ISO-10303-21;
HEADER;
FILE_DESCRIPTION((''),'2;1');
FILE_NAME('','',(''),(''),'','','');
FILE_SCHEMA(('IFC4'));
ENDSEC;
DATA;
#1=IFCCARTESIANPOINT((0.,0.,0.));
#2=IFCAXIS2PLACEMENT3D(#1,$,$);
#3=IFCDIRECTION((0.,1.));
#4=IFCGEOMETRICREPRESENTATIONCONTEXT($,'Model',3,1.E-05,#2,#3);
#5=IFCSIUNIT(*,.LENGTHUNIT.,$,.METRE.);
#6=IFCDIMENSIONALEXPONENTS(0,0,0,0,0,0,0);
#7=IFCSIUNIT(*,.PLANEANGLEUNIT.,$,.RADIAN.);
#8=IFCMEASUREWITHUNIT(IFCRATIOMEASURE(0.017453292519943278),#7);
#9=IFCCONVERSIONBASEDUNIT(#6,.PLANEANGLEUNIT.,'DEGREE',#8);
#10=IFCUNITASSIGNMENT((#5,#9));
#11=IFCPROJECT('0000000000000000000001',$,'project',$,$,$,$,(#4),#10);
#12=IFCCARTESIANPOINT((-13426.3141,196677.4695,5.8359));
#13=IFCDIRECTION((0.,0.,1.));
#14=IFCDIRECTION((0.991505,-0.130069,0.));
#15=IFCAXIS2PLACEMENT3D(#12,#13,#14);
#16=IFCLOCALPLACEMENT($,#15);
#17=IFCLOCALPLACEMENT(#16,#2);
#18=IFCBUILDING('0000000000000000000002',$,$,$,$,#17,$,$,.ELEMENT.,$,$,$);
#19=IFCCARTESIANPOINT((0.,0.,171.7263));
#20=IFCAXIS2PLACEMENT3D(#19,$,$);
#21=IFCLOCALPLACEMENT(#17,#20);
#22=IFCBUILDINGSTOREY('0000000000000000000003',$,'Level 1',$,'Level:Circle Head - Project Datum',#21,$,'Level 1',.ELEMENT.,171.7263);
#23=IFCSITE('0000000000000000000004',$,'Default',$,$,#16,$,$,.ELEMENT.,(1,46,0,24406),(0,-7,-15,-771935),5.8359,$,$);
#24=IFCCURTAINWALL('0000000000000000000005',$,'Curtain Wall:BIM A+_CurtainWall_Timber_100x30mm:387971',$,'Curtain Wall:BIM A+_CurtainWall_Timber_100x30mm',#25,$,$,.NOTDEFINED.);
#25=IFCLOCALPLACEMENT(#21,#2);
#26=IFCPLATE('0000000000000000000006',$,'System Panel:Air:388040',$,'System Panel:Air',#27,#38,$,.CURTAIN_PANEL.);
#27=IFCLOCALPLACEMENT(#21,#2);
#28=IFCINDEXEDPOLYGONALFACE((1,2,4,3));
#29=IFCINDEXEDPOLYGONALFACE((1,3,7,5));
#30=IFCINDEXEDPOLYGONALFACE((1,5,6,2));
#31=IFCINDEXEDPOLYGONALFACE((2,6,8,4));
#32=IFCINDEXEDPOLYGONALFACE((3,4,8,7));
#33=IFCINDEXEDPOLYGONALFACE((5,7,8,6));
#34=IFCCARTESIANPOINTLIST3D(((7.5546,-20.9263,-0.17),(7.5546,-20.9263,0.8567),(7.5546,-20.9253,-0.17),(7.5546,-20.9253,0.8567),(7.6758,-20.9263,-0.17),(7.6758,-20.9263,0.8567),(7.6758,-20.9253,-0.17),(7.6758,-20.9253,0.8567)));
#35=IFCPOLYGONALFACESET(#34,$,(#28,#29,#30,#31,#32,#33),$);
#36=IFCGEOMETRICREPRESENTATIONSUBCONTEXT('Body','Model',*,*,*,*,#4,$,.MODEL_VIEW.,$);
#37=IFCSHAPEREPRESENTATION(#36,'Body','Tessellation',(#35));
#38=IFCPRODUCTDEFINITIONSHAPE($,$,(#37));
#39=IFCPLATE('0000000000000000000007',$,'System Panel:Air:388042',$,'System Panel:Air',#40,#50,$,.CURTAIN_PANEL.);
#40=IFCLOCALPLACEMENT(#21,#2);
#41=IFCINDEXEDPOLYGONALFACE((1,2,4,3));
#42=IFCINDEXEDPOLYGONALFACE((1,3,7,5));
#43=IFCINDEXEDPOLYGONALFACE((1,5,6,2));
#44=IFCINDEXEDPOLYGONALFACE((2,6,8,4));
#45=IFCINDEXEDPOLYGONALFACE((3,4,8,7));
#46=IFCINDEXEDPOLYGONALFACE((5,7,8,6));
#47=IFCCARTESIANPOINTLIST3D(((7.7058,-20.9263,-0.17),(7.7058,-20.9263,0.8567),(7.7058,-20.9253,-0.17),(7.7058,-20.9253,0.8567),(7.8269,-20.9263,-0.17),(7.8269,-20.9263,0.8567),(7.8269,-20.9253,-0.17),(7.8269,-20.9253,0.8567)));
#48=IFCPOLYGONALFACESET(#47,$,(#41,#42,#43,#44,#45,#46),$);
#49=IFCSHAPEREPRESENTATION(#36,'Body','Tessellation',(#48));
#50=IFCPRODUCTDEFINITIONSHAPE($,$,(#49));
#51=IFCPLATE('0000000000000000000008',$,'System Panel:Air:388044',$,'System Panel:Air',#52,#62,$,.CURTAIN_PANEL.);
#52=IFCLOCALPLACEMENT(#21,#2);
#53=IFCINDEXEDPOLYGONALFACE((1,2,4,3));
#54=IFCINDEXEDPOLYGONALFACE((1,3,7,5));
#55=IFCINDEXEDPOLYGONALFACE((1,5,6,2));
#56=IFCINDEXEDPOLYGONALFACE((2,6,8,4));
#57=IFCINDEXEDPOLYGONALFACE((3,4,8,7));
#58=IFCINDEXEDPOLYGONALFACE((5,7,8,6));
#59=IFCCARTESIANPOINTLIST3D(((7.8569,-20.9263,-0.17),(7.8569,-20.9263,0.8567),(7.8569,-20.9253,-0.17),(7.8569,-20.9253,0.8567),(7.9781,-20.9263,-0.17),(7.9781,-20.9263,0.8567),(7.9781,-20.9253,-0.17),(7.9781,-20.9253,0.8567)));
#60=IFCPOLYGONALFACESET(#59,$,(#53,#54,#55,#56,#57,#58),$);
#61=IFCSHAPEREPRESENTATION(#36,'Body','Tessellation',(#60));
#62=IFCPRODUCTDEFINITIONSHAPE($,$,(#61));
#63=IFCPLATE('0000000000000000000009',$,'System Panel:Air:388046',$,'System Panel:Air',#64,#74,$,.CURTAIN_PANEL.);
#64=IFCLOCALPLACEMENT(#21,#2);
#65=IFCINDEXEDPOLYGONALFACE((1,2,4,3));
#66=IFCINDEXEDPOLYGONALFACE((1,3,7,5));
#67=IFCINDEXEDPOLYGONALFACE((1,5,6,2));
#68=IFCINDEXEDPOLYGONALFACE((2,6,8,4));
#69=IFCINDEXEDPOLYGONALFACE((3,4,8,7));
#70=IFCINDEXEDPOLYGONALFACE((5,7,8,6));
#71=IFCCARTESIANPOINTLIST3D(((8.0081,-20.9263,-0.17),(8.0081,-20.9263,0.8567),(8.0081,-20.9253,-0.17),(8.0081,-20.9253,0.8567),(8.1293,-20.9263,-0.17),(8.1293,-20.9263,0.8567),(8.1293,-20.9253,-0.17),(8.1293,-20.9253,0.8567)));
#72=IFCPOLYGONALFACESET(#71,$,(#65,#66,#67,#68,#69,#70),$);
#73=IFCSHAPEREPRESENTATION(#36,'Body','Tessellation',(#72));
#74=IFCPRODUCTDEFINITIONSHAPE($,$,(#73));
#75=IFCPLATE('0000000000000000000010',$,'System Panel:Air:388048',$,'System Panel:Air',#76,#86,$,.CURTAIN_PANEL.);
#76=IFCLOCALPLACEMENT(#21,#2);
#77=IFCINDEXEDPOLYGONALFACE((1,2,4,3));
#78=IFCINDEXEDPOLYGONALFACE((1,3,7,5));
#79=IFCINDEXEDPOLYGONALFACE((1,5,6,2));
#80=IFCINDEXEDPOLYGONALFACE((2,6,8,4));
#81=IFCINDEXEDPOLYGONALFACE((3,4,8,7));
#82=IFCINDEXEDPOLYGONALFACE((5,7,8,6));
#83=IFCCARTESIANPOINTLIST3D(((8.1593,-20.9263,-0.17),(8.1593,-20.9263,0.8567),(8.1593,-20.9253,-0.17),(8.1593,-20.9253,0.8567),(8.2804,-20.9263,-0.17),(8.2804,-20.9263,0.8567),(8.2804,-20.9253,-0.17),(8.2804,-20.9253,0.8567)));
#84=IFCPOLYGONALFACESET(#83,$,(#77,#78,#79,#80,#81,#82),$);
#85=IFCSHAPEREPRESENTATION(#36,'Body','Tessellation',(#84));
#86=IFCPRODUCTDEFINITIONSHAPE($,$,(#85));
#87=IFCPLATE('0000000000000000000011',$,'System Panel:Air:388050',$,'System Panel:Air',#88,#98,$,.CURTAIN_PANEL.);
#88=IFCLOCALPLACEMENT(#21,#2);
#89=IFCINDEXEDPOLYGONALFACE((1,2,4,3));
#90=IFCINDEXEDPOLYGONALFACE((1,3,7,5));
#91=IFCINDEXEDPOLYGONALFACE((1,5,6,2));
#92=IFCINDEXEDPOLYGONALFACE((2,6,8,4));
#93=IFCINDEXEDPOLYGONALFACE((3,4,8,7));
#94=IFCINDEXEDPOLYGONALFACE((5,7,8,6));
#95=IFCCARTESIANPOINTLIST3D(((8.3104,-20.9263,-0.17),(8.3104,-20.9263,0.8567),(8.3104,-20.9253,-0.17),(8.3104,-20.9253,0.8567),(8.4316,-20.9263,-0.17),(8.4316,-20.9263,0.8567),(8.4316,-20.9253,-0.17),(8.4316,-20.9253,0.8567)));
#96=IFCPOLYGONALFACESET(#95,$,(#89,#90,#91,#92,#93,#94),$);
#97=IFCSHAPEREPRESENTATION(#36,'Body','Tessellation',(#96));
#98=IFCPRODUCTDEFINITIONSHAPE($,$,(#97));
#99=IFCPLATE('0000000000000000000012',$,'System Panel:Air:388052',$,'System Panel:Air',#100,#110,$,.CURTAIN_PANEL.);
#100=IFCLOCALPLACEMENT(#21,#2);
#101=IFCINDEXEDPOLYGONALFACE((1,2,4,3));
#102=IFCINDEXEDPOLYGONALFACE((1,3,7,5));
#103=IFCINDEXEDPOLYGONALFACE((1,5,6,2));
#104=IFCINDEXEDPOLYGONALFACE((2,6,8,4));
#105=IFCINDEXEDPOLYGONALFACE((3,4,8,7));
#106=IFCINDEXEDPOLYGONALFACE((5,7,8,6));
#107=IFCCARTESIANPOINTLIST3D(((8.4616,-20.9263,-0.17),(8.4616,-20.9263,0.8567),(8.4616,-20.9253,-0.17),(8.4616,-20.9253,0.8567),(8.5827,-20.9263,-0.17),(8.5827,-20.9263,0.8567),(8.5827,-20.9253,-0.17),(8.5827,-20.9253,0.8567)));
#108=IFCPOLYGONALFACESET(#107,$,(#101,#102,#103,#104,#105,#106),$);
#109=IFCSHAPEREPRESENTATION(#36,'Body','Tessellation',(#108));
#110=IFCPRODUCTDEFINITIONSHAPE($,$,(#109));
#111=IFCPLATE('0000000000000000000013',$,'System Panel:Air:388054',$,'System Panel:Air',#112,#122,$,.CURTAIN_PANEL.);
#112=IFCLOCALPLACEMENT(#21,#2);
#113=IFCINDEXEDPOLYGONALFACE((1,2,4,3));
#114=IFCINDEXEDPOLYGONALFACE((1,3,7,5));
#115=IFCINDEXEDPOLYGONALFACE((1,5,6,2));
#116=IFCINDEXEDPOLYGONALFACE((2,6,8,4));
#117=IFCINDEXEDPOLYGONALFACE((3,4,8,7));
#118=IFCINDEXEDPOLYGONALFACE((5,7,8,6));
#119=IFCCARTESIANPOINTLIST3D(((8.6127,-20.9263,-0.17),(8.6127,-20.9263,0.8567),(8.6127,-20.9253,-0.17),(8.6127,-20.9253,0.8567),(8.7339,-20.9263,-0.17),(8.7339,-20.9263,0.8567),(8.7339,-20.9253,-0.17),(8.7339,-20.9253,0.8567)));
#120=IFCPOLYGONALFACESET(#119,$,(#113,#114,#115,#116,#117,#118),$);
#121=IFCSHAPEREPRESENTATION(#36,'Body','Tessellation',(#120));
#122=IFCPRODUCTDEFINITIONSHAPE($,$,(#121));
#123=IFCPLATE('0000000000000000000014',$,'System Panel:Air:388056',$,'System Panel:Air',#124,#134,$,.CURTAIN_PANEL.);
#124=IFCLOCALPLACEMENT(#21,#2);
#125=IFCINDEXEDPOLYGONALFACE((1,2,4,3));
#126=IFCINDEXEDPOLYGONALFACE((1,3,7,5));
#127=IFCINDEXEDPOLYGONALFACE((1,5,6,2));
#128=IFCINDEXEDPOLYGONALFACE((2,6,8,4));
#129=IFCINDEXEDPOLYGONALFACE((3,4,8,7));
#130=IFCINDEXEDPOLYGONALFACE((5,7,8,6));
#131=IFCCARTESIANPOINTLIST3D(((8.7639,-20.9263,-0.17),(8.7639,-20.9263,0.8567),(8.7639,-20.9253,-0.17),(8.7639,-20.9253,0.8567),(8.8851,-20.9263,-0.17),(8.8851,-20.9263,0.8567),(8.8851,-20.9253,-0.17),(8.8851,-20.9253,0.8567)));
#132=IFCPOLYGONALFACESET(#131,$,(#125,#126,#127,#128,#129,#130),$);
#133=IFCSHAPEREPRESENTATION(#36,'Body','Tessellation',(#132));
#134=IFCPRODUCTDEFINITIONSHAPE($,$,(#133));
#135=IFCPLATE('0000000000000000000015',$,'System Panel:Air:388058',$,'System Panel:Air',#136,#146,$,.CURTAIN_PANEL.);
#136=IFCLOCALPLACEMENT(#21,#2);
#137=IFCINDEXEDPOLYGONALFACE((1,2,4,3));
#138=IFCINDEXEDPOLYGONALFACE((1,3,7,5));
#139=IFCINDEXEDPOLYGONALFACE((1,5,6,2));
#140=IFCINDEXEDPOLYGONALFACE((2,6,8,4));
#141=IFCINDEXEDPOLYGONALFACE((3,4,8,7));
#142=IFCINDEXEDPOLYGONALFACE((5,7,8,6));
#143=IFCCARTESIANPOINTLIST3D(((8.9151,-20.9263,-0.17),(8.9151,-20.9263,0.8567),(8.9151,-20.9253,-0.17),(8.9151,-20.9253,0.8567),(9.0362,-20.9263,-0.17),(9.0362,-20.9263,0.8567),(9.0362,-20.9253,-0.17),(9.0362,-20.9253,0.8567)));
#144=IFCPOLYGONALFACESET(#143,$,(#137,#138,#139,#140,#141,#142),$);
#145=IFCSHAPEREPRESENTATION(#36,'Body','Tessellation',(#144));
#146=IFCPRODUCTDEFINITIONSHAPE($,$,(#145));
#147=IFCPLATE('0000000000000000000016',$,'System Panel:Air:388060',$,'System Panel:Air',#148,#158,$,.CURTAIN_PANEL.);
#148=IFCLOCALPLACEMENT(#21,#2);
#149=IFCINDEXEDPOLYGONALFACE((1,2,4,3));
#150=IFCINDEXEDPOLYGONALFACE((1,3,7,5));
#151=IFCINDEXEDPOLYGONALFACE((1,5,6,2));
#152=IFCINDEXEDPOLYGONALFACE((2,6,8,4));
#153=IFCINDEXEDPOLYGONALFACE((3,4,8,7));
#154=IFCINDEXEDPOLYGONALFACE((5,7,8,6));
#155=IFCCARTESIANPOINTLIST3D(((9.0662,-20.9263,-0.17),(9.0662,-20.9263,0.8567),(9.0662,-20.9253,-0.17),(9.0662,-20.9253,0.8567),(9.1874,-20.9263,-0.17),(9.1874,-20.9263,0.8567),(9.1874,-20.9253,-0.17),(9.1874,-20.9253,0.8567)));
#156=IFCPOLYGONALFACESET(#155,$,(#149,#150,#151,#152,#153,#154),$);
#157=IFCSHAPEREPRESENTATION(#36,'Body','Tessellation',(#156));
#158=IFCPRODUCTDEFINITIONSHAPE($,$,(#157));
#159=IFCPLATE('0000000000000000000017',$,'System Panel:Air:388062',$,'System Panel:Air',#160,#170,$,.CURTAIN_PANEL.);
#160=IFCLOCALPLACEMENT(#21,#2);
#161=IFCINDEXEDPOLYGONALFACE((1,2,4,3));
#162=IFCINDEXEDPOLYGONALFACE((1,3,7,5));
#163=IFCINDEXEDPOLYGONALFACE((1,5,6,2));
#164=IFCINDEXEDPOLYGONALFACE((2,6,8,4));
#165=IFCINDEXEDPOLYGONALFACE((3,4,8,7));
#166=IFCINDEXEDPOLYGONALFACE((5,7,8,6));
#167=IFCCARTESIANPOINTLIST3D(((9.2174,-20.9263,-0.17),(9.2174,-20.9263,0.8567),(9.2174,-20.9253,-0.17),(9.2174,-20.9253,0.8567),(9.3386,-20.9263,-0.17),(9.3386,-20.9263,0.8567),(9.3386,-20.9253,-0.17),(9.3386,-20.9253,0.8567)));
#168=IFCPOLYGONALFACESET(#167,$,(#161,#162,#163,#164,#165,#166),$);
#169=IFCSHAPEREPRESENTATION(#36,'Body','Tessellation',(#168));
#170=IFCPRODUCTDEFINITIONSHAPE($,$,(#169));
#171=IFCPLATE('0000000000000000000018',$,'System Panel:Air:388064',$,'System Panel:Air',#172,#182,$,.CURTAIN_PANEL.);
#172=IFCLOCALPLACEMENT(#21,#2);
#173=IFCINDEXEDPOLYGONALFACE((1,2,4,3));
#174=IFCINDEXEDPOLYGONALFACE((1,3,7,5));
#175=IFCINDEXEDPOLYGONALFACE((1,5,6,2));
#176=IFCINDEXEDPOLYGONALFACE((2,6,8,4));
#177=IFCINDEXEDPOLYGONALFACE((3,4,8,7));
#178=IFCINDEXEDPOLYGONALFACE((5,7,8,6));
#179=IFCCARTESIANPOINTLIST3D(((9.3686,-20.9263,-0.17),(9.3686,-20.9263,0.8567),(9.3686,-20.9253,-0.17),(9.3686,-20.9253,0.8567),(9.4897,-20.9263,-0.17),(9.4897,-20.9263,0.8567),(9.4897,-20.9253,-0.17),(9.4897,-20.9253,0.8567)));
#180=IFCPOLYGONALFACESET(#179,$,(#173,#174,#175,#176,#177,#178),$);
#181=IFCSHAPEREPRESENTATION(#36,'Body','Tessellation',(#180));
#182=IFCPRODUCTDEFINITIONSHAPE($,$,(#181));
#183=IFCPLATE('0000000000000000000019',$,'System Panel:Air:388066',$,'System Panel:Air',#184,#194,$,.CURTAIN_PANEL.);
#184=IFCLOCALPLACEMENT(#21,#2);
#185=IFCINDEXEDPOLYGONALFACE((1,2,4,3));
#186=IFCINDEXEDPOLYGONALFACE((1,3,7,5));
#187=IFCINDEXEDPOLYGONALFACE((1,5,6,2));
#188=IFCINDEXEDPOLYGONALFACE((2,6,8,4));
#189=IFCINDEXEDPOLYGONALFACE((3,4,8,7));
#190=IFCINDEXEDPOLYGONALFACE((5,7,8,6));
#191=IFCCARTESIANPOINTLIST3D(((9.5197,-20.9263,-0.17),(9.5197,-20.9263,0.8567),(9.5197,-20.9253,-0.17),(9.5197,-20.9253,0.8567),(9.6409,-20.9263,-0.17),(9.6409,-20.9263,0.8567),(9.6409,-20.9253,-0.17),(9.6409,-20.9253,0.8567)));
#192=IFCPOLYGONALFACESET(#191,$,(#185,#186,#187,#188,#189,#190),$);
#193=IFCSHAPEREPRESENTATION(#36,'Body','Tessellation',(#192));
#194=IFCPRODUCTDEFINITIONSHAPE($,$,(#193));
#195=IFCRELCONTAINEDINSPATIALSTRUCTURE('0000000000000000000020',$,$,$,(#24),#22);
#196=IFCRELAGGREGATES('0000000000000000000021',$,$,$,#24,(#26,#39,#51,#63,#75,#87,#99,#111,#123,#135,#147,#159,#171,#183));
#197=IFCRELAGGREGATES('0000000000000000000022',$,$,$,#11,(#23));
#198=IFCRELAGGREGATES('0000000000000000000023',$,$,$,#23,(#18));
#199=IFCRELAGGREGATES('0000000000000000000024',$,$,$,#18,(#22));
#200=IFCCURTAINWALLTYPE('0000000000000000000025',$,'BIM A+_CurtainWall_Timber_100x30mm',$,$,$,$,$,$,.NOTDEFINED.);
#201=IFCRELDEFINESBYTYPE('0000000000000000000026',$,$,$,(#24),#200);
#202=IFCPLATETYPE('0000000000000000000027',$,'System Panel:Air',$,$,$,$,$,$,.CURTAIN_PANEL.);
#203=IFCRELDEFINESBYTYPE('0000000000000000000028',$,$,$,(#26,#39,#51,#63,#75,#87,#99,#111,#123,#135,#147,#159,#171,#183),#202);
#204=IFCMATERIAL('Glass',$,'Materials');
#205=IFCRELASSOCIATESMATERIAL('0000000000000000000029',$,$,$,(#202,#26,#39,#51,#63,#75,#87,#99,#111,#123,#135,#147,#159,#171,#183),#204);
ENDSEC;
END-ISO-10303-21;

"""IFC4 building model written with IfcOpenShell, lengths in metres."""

from ifc_helpers import new_model, entity, si_unit, converted_unit, direction, frame, origin, place, context, subcontext, project, spatial, indexed_curve, outline, extrude, source, transform, mapped, material, type_object, type_shapes, element, aggregate, save


model = new_model("IFC4")

# Units and contexts
model_context = context("Model", 3, precision=1e-05, world=origin(), true_north=direction((0.0, 1.0)))
body_context = subcontext(model_context, "Body", "Model", "MODEL_VIEW")
ifc_project = project(units=[si_unit("LENGTHUNIT", "METRE"), converted_unit("PLANEANGLEUNIT", "DEGREE", entity("IfcRatioMeasure", 0.017453292519943278), si_unit("PLANEANGLEUNIT", "RADIAN"), dimensions=[0, 0, 0, 0, 0, 0, 0])], contexts=[model_context])

# Site, building, storey
site_placement = place(None, frame((-13426.3141, 196677.4695, 5.8359), z_axis=(0.0, 0.0, 1.0), x_axis=(0.991505, -0.130069, 0.0)))
site = spatial("IfcSite", under=ifc_project, at=site_placement, Name="Default", CompositionType="ELEMENT", RefLatitude=(1, 46, 0, 24406), RefLongitude=(0, -7, -15, -771935), RefElevation=5.8359)
building_placement = place(site_placement, origin())
building = spatial("IfcBuilding", under=site, at=building_placement, CompositionType="ELEMENT")
storey_placement = place(building_placement, frame((0.0, 0.0, 171.7263)))
storey = spatial("IfcBuildingStorey", under=building, at=storey_placement, Name="Level 1", ObjectType="Level:Circle Head - Project Datum", LongName="Level 1", CompositionType="ELEMENT", Elevation=171.7263)

# Shared definitions
ifc_material_1 = material(Name="Glass", Category="Materials")

# Curtain wall, plates
curtain_wall_type_1 = type_object("IfcCurtainWallType", Name="BIM A+_CurtainWall_Timber_100x30mm", PredefinedType="NOTDEFINED")
curtain_wall_1_placement = place(storey_placement, frame((0.0, 0.0, -171.7263)))
curtain_wall_1 = element("IfcCurtainWall", 1, at=curtain_wall_1_placement, inside=storey, type_object=curtain_wall_type_1, Name="Curtain Wall:BIM A+_CurtainWall_Timber_100x30mm:387971", ObjectType="Curtain Wall:BIM A+_CurtainWall_Timber_100x30mm", PredefinedType="NOTDEFINED")
plate_type_1 = type_object("IfcPlateType", Name="System Panel:Air", PredefinedType="CURTAIN_PANEL", material=ifc_material_1)
shared_shape_1 = source(origin(), body_context, "Body", "SweptSolid", [
    extrude(outline(indexed_curve([(-0.0005, -0.0606), (0.0005, -0.0606), (0.0005, 0.0606), (-0.0005, 0.0606), (-0.0005, -0.0606)], self_intersect=False)), frame((0.0, 0.0, 0.0), z_axis=(0.0, 0.0, 1.0), x_axis=(0.0, 1.0, 0.0)), (0.0, 0.0, 1.0), 1.0267),
])
type_shapes(plate_type_1, [shared_shape_1])
plate_1_placement = place(curtain_wall_1_placement, frame((7.6152, -20.9258, 171.5563)))
plate_1 = element("IfcPlate", 2, at=plate_1_placement, type_object=plate_type_1, material=ifc_material_1, Name="System Panel:Air:388040", ObjectType="System Panel:Air", PredefinedType="CURTAIN_PANEL", context=body_context, shape_type="MappedRepresentation", body=[
    mapped(shared_shape_1, transform((0.0, 0.0, 0.0), scale=1.0)),
])
plate_2_placement = place(curtain_wall_1_placement, frame((7.7664, -20.9258, 171.5563)))
plate_2 = element("IfcPlate", 3, at=plate_2_placement, type_object=plate_type_1, material=ifc_material_1, Name="System Panel:Air:388042", ObjectType="System Panel:Air", PredefinedType="CURTAIN_PANEL", context=body_context, shape_type="MappedRepresentation", body=[
    mapped(shared_shape_1, transform((0.0, 0.0, 0.0), scale=1.0)),
])
plate_3_placement = place(curtain_wall_1_placement, frame((7.9175, -20.9258, 171.5563)))
plate_3 = element("IfcPlate", 4, at=plate_3_placement, type_object=plate_type_1, material=ifc_material_1, Name="System Panel:Air:388044", ObjectType="System Panel:Air", PredefinedType="CURTAIN_PANEL", context=body_context, shape_type="MappedRepresentation", body=[
    mapped(shared_shape_1, transform((0.0, 0.0, 0.0), scale=1.0)),
])
plate_4_placement = place(curtain_wall_1_placement, frame((8.0687, -20.9258, 171.5563)))
plate_4 = element("IfcPlate", 5, at=plate_4_placement, type_object=plate_type_1, material=ifc_material_1, Name="System Panel:Air:388046", ObjectType="System Panel:Air", PredefinedType="CURTAIN_PANEL", context=body_context, shape_type="MappedRepresentation", body=[
    mapped(shared_shape_1, transform((0.0, 0.0, 0.0), scale=1.0)),
])
plate_5_placement = place(curtain_wall_1_placement, frame((8.2198, -20.9258, 171.5563)))
plate_5 = element("IfcPlate", 6, at=plate_5_placement, type_object=plate_type_1, material=ifc_material_1, Name="System Panel:Air:388048", ObjectType="System Panel:Air", PredefinedType="CURTAIN_PANEL", context=body_context, shape_type="MappedRepresentation", body=[
    mapped(shared_shape_1, transform((0.0, 0.0, 0.0), scale=1.0)),
])
plate_6_placement = place(curtain_wall_1_placement, frame((8.371, -20.9258, 171.5563)))
plate_6 = element("IfcPlate", 7, at=plate_6_placement, type_object=plate_type_1, material=ifc_material_1, Name="System Panel:Air:388050", ObjectType="System Panel:Air", PredefinedType="CURTAIN_PANEL", context=body_context, shape_type="MappedRepresentation", body=[
    mapped(shared_shape_1, transform((0.0, 0.0, 0.0), scale=1.0)),
])
plate_7_placement = place(curtain_wall_1_placement, frame((8.5222, -20.9258, 171.5563)))
plate_7 = element("IfcPlate", 8, at=plate_7_placement, type_object=plate_type_1, material=ifc_material_1, Name="System Panel:Air:388052", ObjectType="System Panel:Air", PredefinedType="CURTAIN_PANEL", context=body_context, shape_type="MappedRepresentation", body=[
    mapped(shared_shape_1, transform((0.0, 0.0, 0.0), scale=1.0)),
])
plate_8_placement = place(curtain_wall_1_placement, frame((8.6733, -20.9258, 171.5563)))
plate_8 = element("IfcPlate", 9, at=plate_8_placement, type_object=plate_type_1, material=ifc_material_1, Name="System Panel:Air:388054", ObjectType="System Panel:Air", PredefinedType="CURTAIN_PANEL", context=body_context, shape_type="MappedRepresentation", body=[
    mapped(shared_shape_1, transform((0.0, 0.0, 0.0), scale=1.0)),
])
plate_9_placement = place(curtain_wall_1_placement, frame((8.8245, -20.9258, 171.5563)))
plate_9 = element("IfcPlate", 10, at=plate_9_placement, type_object=plate_type_1, material=ifc_material_1, Name="System Panel:Air:388056", ObjectType="System Panel:Air", PredefinedType="CURTAIN_PANEL", context=body_context, shape_type="MappedRepresentation", body=[
    mapped(shared_shape_1, transform((0.0, 0.0, 0.0), scale=1.0)),
])
plate_10_placement = place(curtain_wall_1_placement, frame((8.9757, -20.9258, 171.5563)))
plate_10 = element("IfcPlate", 11, at=plate_10_placement, type_object=plate_type_1, material=ifc_material_1, Name="System Panel:Air:388058", ObjectType="System Panel:Air", PredefinedType="CURTAIN_PANEL", context=body_context, shape_type="MappedRepresentation", body=[
    mapped(shared_shape_1, transform((0.0, 0.0, 0.0), scale=1.0)),
])
plate_11_placement = place(curtain_wall_1_placement, frame((9.1268, -20.9258, 171.5563)))
plate_11 = element("IfcPlate", 12, at=plate_11_placement, type_object=plate_type_1, material=ifc_material_1, Name="System Panel:Air:388060", ObjectType="System Panel:Air", PredefinedType="CURTAIN_PANEL", context=body_context, shape_type="MappedRepresentation", body=[
    mapped(shared_shape_1, transform((0.0, 0.0, 0.0), scale=1.0)),
])
plate_12_placement = place(curtain_wall_1_placement, frame((9.278, -20.9258, 171.5563)))
plate_12 = element("IfcPlate", 13, at=plate_12_placement, type_object=plate_type_1, material=ifc_material_1, Name="System Panel:Air:388062", ObjectType="System Panel:Air", PredefinedType="CURTAIN_PANEL", context=body_context, shape_type="MappedRepresentation", body=[
    mapped(shared_shape_1, transform((0.0, 0.0, 0.0), scale=1.0)),
])
plate_13_placement = place(curtain_wall_1_placement, frame((9.4291, -20.9258, 171.5563)))
plate_13 = element("IfcPlate", 14, at=plate_13_placement, type_object=plate_type_1, material=ifc_material_1, Name="System Panel:Air:388064", ObjectType="System Panel:Air", PredefinedType="CURTAIN_PANEL", context=body_context, shape_type="MappedRepresentation", body=[
    mapped(shared_shape_1, transform((0.0, 0.0, 0.0), scale=1.0)),
])
plate_14_placement = place(curtain_wall_1_placement, frame((9.5803, -20.9258, 171.5563)))
plate_14 = element("IfcPlate", 15, at=plate_14_placement, type_object=plate_type_1, material=ifc_material_1, Name="System Panel:Air:388066", ObjectType="System Panel:Air", PredefinedType="CURTAIN_PANEL", context=body_context, shape_type="MappedRepresentation", body=[
    mapped(shared_shape_1, transform((0.0, 0.0, 0.0), scale=1.0)),
])
aggregate(curtain_wall_1, [plate_1, plate_2, plate_3, plate_4, plate_5, plate_6, plate_7, plate_8, plate_9, plate_10, plate_11, plate_12, plate_13, plate_14])

save(model, "model.ifc")
